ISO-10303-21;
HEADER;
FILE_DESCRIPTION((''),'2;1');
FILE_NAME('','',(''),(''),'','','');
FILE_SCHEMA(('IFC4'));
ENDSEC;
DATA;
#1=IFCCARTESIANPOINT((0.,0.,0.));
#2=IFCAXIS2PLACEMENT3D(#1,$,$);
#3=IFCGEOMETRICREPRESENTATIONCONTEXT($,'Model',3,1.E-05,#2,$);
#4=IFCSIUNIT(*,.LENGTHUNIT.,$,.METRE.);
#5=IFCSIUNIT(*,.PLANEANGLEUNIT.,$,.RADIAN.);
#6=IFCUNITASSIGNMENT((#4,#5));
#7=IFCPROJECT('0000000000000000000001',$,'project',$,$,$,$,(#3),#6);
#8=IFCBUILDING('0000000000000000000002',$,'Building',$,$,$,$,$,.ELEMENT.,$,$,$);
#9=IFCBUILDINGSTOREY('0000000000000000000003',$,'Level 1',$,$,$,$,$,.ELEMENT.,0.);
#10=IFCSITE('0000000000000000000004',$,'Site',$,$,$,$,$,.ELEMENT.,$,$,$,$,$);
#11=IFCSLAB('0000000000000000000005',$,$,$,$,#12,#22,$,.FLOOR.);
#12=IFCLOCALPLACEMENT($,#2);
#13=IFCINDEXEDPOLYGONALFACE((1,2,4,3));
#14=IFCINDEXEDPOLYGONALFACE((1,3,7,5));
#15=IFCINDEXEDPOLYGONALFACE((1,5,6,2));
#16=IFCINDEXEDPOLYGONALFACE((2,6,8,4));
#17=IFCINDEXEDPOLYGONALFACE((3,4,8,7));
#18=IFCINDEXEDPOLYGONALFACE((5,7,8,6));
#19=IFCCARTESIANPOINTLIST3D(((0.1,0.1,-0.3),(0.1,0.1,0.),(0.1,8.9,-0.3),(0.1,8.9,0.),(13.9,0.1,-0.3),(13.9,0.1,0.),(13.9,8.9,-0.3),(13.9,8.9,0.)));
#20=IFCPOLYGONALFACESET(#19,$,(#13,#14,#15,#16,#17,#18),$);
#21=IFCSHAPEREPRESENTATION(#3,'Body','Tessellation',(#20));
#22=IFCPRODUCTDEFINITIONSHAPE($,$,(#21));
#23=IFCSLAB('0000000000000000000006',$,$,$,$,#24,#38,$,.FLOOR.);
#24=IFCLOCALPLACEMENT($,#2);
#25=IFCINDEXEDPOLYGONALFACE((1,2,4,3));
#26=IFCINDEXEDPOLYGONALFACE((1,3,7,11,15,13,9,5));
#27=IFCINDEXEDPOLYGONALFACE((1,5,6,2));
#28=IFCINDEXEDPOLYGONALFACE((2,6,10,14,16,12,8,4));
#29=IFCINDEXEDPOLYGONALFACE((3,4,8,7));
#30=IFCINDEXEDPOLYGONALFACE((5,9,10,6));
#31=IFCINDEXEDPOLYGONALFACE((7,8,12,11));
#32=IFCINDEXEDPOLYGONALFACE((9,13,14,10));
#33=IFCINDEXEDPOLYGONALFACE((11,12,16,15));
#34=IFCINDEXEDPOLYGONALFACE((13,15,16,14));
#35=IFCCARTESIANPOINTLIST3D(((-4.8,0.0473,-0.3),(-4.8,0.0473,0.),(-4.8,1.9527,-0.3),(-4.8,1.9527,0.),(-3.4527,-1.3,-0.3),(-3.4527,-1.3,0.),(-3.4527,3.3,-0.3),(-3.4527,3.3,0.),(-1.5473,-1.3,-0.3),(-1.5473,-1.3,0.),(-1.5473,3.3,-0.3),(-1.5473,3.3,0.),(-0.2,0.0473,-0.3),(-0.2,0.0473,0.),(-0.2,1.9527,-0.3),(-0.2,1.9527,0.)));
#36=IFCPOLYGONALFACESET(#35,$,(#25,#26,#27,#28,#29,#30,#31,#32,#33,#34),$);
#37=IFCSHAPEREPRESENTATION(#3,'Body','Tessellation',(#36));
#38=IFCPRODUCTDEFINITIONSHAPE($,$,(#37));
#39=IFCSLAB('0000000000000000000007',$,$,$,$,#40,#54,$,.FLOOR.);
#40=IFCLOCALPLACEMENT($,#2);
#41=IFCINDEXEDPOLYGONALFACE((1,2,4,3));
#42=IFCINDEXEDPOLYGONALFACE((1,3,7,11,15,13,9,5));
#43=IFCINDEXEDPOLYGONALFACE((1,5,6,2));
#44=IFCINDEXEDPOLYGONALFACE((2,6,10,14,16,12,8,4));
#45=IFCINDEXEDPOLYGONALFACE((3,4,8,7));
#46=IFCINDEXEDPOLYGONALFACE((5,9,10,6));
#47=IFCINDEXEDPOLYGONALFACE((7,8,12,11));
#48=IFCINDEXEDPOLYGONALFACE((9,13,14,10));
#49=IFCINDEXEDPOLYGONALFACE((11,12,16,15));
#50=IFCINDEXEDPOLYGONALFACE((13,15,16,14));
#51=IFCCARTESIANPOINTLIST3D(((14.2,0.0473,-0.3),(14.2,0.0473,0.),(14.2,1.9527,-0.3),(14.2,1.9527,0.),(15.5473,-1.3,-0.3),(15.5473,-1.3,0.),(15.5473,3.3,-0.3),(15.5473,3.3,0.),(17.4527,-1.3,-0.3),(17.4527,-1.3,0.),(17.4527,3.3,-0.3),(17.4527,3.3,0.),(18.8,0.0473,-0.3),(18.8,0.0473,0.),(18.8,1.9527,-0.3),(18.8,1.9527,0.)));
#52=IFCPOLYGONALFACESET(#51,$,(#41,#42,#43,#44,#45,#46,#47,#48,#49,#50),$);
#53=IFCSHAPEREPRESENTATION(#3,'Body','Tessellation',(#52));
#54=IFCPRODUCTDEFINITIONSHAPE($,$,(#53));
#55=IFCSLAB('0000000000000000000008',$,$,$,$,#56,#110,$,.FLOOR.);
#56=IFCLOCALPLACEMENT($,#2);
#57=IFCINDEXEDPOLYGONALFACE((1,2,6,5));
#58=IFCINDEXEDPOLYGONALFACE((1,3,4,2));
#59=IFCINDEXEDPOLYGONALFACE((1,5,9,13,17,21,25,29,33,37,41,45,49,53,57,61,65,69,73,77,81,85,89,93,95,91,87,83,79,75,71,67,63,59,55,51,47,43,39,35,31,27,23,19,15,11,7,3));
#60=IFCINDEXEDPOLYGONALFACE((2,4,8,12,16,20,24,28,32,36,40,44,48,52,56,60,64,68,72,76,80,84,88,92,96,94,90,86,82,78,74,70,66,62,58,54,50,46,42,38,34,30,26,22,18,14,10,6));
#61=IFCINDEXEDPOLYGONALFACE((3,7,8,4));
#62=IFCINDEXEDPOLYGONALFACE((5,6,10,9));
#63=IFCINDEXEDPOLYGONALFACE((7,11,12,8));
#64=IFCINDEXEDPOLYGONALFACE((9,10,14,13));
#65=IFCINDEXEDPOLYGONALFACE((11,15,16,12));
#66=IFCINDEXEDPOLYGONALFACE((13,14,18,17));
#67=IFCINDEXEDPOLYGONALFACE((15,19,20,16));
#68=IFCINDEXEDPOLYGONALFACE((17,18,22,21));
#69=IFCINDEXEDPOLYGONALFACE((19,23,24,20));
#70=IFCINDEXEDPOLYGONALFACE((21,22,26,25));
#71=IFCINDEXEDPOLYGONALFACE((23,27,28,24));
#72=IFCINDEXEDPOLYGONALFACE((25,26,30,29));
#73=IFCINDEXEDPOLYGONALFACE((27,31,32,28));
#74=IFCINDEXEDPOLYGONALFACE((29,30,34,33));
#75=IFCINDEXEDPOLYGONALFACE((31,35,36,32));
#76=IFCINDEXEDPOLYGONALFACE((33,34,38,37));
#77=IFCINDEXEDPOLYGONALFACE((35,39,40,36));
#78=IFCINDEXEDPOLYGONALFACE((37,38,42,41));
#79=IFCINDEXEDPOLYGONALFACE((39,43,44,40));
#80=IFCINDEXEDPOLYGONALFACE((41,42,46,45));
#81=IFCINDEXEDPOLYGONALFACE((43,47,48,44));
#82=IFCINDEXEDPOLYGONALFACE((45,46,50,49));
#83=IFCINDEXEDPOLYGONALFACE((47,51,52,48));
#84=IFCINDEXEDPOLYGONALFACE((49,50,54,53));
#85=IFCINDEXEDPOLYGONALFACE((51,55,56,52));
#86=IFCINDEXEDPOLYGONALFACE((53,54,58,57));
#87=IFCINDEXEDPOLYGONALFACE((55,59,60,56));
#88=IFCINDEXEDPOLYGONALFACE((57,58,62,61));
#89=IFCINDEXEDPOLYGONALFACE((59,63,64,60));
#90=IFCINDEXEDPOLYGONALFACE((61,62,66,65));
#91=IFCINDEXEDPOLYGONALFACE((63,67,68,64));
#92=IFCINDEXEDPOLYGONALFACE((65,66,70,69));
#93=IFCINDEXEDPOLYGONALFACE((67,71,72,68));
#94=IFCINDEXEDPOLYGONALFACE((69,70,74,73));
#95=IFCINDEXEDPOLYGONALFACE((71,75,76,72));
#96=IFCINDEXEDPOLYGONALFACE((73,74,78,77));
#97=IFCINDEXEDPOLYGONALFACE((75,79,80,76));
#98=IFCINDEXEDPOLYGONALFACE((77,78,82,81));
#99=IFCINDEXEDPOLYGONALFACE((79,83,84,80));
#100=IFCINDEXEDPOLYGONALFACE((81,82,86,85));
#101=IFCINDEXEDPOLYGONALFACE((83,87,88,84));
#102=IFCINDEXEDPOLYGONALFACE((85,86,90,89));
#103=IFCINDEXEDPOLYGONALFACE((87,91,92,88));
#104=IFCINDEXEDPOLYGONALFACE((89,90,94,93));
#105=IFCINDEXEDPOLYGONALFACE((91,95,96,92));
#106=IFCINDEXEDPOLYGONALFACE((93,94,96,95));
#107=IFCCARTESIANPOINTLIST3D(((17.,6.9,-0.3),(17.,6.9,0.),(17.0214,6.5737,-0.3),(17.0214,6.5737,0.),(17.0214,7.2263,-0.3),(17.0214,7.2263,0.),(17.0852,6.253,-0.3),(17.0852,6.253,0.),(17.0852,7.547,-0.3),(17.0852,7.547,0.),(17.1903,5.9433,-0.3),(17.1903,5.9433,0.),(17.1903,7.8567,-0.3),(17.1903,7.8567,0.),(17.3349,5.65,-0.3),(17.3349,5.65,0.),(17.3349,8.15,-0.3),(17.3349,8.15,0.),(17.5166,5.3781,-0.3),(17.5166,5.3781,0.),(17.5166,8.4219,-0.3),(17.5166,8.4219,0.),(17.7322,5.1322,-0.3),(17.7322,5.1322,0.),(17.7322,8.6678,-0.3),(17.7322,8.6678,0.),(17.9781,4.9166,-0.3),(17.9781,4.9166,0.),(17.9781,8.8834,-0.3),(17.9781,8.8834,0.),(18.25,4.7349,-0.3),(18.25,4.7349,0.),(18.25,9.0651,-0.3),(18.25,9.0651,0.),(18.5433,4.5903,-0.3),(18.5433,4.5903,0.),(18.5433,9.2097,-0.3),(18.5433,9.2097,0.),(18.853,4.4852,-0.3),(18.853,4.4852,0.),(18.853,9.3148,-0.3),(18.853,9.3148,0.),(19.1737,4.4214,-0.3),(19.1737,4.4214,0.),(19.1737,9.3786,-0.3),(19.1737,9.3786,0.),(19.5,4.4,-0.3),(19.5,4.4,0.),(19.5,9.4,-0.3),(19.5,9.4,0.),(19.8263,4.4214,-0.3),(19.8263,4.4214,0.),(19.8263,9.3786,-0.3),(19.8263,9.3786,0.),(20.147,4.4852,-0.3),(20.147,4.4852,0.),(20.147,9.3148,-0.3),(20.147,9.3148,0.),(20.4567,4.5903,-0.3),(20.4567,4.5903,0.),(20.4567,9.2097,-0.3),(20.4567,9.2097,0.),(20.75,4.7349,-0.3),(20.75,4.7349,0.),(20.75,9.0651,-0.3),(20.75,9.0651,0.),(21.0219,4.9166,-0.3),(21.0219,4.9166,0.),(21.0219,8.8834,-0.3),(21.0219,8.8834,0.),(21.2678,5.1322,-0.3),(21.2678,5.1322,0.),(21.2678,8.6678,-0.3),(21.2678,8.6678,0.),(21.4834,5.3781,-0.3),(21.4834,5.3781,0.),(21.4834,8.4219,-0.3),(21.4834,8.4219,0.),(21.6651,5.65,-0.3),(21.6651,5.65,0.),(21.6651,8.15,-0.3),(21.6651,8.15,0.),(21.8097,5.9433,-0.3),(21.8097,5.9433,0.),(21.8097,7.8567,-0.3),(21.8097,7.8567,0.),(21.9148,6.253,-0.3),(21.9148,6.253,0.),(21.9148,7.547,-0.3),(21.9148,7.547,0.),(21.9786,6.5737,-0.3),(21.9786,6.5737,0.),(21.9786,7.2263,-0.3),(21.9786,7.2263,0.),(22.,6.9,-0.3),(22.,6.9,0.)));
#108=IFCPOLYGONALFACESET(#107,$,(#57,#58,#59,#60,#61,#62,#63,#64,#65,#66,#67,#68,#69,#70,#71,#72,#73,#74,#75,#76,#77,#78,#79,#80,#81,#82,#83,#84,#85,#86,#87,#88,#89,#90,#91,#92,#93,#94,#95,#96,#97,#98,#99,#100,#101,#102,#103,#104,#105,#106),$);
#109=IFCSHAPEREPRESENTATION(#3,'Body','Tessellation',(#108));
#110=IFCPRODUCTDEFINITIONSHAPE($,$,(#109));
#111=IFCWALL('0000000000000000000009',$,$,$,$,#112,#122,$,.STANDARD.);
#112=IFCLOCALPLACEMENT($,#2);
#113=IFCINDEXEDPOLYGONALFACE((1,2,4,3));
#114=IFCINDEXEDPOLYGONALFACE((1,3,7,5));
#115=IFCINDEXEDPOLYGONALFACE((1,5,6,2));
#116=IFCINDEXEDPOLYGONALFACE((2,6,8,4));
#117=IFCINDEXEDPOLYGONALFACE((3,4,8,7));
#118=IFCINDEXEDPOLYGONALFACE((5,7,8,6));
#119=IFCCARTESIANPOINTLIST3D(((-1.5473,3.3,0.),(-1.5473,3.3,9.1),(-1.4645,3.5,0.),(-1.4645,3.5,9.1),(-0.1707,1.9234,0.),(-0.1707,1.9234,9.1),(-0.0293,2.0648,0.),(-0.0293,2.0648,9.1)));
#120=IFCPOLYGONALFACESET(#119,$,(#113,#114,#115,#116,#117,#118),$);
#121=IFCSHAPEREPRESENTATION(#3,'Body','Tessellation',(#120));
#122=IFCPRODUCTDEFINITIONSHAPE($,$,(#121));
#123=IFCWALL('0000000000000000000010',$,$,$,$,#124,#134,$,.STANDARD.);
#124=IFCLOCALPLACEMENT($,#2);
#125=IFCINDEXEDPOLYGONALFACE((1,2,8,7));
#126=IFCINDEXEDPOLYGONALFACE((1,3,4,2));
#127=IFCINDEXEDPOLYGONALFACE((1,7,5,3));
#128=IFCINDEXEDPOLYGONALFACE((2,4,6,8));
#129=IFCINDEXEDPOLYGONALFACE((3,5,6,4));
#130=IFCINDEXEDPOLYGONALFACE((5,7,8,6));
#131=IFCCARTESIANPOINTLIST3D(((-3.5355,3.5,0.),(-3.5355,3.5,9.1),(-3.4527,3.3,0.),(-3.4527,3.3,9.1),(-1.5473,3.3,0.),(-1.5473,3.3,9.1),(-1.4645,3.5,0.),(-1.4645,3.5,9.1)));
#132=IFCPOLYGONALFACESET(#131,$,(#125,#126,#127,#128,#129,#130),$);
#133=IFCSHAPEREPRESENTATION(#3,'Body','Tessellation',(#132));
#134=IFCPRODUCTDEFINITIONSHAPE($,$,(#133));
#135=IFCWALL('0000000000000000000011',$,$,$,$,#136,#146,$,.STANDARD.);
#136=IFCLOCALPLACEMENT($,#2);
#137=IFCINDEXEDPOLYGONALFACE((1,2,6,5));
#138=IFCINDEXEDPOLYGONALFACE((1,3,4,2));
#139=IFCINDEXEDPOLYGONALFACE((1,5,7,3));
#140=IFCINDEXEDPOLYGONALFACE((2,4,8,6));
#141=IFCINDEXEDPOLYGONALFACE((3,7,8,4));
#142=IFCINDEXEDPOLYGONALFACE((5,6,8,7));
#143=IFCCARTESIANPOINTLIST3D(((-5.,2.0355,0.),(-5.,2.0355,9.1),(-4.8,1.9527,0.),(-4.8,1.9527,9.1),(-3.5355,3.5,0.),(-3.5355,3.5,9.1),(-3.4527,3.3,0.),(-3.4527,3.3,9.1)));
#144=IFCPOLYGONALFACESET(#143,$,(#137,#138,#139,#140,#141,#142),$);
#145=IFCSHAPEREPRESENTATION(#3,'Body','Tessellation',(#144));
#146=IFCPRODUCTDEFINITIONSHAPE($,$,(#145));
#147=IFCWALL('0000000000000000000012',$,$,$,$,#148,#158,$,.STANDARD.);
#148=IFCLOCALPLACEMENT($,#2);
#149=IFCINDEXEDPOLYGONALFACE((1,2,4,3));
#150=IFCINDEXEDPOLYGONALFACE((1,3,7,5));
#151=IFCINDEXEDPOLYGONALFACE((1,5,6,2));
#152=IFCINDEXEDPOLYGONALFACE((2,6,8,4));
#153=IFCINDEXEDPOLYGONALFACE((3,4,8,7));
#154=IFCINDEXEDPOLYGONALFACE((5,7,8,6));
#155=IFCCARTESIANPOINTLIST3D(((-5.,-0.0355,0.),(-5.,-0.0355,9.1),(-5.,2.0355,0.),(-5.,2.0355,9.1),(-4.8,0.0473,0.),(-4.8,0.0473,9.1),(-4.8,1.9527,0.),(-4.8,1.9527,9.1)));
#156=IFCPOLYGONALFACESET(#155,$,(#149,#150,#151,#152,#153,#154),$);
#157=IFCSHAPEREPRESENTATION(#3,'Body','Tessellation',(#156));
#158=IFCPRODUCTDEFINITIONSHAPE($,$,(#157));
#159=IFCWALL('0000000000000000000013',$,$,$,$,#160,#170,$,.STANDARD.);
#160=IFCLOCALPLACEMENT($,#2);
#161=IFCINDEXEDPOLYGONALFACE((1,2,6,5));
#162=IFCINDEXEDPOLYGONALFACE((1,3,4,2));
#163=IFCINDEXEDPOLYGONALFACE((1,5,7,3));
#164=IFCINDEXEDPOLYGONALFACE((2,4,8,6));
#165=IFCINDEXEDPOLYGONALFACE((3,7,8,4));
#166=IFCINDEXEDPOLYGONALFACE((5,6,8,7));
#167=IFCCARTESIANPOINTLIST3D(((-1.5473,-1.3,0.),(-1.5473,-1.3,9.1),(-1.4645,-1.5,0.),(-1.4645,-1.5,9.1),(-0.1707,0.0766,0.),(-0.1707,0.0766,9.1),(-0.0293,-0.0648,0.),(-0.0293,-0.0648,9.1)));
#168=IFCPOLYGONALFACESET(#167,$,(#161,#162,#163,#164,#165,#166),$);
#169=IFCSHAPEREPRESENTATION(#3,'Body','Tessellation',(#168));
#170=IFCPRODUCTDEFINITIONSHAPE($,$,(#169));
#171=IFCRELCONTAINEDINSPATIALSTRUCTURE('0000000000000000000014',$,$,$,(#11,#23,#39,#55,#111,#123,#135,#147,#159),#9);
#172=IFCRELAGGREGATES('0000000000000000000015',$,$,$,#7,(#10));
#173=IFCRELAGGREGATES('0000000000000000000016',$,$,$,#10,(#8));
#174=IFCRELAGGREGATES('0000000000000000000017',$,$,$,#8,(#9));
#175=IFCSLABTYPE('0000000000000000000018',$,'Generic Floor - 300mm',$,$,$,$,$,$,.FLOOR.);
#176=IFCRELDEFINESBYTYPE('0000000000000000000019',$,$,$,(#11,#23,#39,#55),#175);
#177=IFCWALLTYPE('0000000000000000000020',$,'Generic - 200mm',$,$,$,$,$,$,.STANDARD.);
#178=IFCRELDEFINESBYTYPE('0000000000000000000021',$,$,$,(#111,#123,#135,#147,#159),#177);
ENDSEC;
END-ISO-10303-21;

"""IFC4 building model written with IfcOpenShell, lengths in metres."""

from ifc_helpers import new_model, si_unit, frame, origin, place, context, project, spatial, polyline, outline, extrude, type_object, element, save


model = new_model("IFC4")

# Units and contexts
model_context = context("Model", 3, precision=1e-05, world=origin())
ifc_project = project(units=[si_unit("LENGTHUNIT", "METRE"), si_unit("PLANEANGLEUNIT", "RADIAN")], contexts=[model_context])

# Site, building, storey
site = spatial("IfcSite", under=ifc_project, Name="Site", CompositionType="ELEMENT")
building = spatial("IfcBuilding", under=site, Name="Building", CompositionType="ELEMENT")
storey = spatial("IfcBuildingStorey", under=building, Name="Level 1", CompositionType="ELEMENT", Elevation=0.0)

# Slabs
slab_type = type_object("IfcSlabType", Name="Generic Floor - 300mm", PredefinedType="FLOOR")
slab_1_placement = place(None, origin())
element("IfcSlab", 1, at=slab_1_placement, inside=storey, type_object=slab_type, PredefinedType="FLOOR", context=model_context, shape_type="SweptSolid", body=[
    extrude(outline(polyline([(0.1, 0.1), (13.9, 0.1), (13.9, 8.9), (0.1, 8.9), (0.1, 0.1)])), origin(), (0.0, 0.0, -1.0), 0.3),
])
slab_2_placement = place(None, origin())
element("IfcSlab", 2, at=slab_2_placement, inside=storey, type_object=slab_type, PredefinedType="FLOOR", context=model_context, shape_type="SweptSolid", body=[
    extrude(outline(polyline([(-0.2, 1.9527), (-1.5473, 3.3), (-3.4527, 3.3), (-4.8, 1.9527), (-4.8, 0.0473), (-3.4527, -1.3), (-1.5473, -1.3), (-0.2, 0.0473), (-0.2, 1.9527)])), origin(), (0.0, 0.0, -1.0), 0.3),
])
slab_3_placement = place(None, origin())
element("IfcSlab", 3, at=slab_3_placement, inside=storey, type_object=slab_type, PredefinedType="FLOOR", context=model_context, shape_type="SweptSolid", body=[
    extrude(outline(polyline([(18.8, 1.9527), (17.4527, 3.3), (15.5473, 3.3), (14.2, 1.9527), (14.2, 0.0473), (15.5473, -1.3), (17.4527, -1.3), (18.8, 0.0473), (18.8, 1.9527)])), origin(), (0.0, 0.0, -1.0), 0.3),
])
slab_4_placement = place(None, origin())
element("IfcSlab", 4, at=slab_4_placement, inside=storey, type_object=slab_type, PredefinedType="FLOOR", context=model_context, shape_type="SweptSolid", body=[
    extrude(outline(polyline([(22.0, 6.9), (21.9786, 7.2263), (21.9148, 7.547), (21.8097, 7.8567), (21.6651, 8.15), (21.4834, 8.4219), (21.2678, 8.6678), (21.0219, 8.8834), (20.75, 9.0651), (20.4567, 9.2097), (20.147, 9.3148), (19.8263, 9.3786), (19.5, 9.4), (19.1737, 9.3786), (18.853, 9.3148), (18.5433, 9.2097), (18.25, 9.0651), (17.9781, 8.8834), (17.7322, 8.6678), (17.5166, 8.4219), (17.3349, 8.15), (17.1903, 7.8567), (17.0852, 7.547), (17.0214, 7.2263), (17.0, 6.9), (17.0214, 6.5737), (17.0852, 6.253), (17.1903, 5.9433), (17.3349, 5.65), (17.5166, 5.3781), (17.7322, 5.1322), (17.9781, 4.9166), (18.25, 4.7349), (18.5433, 4.5903), (18.853, 4.4852), (19.1737, 4.4214), (19.5, 4.4), (19.8263, 4.4214), (20.147, 4.4852), (20.4567, 4.5903), (20.75, 4.7349), (21.0219, 4.9166), (21.2678, 5.1322), (21.4834, 5.3781), (21.6651, 5.65), (21.8097, 5.9433), (21.9148, 6.253), (21.9786, 6.5737), (22.0, 6.9)])), origin(), (0.0, 0.0, -1.0), 0.3),
])

# Walls
wall_type_1 = type_object("IfcWallType", Name="Generic - 200mm", PredefinedType="STANDARD")
wall_1_placement = place(None, frame((-1.5059, 3.4, 0.0), z_axis=(0.0, 0.0, 1.0), x_axis=(0.707107, -0.707107, 0.0)))
element("IfcWall", 5, at=wall_1_placement, inside=storey, type_object=wall_type_1, PredefinedType="STANDARD", context=model_context, shape_type="SweptSolid", body=[
    extrude(outline(polyline([(0.0414, -0.1), (1.9882, -0.1), (1.9882, 0.1), (-0.0414, 0.1), (0.0414, -0.1)])), origin(), (0.0, 0.0, 1.0), 9.1),
])
wall_2_placement = place(None, frame((-3.4941, 3.4, 0.0), z_axis=(0.0, 0.0, 1.0), x_axis=(1.0, 0.0, 0.0)))
element("IfcWall", 6, at=wall_2_placement, inside=storey, type_object=wall_type_1, PredefinedType="STANDARD", context=model_context, shape_type="SweptSolid", body=[
    extrude(outline(polyline([(0.0414, -0.1), (1.9468, -0.1), (2.0296, 0.1), (-0.0414, 0.1), (0.0414, -0.1)])), origin(), (0.0, 0.0, 1.0), 9.1),
])
wall_3_placement = place(None, frame((-4.9, 1.9941, 0.0), z_axis=(0.0, 0.0, 1.0), x_axis=(0.707107, 0.707107, 0.0)))
element("IfcWall", 7, at=wall_3_placement, inside=storey, type_object=wall_type_1, PredefinedType="STANDARD", context=model_context, shape_type="SweptSolid", body=[
    extrude(outline(polyline([(0.0414, -0.1), (1.9468, -0.1), (2.0296, 0.1), (-0.0414, 0.1), (0.0414, -0.1)])), origin(), (0.0, 0.0, 1.0), 9.1),
])
wall_4_placement = place(None, frame((-4.9, 0.0059, 0.0), z_axis=(0.0, 0.0, 1.0), x_axis=(0.0, 1.0, 0.0)))
element("IfcWall", 8, at=wall_4_placement, inside=storey, type_object=wall_type_1, PredefinedType="STANDARD", context=model_context, shape_type="SweptSolid", body=[
    extrude(outline(polyline([(0.0414, -0.1), (1.9468, -0.1), (2.0296, 0.1), (-0.0414, 0.1), (0.0414, -0.1)])), origin(), (0.0, 0.0, 1.0), 9.1),
])

# Wall
wall_5_placement = place(None, frame((-0.1, 0.0059, 0.0), z_axis=(0.0, 0.0, 1.0), x_axis=(-0.707107, -0.707107, 0.0)))
element("IfcWall", 9, at=wall_5_placement, inside=storey, type_object=wall_type_1, PredefinedType="STANDARD", context=model_context, shape_type="SweptSolid", body=[
    extrude(outline(polyline([(0.0, -0.1), (1.9468, -0.1), (2.0296, 0.1), (0.0, 0.1), (0.0, -0.1)])), origin(), (0.0, 0.0, 1.0), 9.1),
])

save(model, "model.ifc")
